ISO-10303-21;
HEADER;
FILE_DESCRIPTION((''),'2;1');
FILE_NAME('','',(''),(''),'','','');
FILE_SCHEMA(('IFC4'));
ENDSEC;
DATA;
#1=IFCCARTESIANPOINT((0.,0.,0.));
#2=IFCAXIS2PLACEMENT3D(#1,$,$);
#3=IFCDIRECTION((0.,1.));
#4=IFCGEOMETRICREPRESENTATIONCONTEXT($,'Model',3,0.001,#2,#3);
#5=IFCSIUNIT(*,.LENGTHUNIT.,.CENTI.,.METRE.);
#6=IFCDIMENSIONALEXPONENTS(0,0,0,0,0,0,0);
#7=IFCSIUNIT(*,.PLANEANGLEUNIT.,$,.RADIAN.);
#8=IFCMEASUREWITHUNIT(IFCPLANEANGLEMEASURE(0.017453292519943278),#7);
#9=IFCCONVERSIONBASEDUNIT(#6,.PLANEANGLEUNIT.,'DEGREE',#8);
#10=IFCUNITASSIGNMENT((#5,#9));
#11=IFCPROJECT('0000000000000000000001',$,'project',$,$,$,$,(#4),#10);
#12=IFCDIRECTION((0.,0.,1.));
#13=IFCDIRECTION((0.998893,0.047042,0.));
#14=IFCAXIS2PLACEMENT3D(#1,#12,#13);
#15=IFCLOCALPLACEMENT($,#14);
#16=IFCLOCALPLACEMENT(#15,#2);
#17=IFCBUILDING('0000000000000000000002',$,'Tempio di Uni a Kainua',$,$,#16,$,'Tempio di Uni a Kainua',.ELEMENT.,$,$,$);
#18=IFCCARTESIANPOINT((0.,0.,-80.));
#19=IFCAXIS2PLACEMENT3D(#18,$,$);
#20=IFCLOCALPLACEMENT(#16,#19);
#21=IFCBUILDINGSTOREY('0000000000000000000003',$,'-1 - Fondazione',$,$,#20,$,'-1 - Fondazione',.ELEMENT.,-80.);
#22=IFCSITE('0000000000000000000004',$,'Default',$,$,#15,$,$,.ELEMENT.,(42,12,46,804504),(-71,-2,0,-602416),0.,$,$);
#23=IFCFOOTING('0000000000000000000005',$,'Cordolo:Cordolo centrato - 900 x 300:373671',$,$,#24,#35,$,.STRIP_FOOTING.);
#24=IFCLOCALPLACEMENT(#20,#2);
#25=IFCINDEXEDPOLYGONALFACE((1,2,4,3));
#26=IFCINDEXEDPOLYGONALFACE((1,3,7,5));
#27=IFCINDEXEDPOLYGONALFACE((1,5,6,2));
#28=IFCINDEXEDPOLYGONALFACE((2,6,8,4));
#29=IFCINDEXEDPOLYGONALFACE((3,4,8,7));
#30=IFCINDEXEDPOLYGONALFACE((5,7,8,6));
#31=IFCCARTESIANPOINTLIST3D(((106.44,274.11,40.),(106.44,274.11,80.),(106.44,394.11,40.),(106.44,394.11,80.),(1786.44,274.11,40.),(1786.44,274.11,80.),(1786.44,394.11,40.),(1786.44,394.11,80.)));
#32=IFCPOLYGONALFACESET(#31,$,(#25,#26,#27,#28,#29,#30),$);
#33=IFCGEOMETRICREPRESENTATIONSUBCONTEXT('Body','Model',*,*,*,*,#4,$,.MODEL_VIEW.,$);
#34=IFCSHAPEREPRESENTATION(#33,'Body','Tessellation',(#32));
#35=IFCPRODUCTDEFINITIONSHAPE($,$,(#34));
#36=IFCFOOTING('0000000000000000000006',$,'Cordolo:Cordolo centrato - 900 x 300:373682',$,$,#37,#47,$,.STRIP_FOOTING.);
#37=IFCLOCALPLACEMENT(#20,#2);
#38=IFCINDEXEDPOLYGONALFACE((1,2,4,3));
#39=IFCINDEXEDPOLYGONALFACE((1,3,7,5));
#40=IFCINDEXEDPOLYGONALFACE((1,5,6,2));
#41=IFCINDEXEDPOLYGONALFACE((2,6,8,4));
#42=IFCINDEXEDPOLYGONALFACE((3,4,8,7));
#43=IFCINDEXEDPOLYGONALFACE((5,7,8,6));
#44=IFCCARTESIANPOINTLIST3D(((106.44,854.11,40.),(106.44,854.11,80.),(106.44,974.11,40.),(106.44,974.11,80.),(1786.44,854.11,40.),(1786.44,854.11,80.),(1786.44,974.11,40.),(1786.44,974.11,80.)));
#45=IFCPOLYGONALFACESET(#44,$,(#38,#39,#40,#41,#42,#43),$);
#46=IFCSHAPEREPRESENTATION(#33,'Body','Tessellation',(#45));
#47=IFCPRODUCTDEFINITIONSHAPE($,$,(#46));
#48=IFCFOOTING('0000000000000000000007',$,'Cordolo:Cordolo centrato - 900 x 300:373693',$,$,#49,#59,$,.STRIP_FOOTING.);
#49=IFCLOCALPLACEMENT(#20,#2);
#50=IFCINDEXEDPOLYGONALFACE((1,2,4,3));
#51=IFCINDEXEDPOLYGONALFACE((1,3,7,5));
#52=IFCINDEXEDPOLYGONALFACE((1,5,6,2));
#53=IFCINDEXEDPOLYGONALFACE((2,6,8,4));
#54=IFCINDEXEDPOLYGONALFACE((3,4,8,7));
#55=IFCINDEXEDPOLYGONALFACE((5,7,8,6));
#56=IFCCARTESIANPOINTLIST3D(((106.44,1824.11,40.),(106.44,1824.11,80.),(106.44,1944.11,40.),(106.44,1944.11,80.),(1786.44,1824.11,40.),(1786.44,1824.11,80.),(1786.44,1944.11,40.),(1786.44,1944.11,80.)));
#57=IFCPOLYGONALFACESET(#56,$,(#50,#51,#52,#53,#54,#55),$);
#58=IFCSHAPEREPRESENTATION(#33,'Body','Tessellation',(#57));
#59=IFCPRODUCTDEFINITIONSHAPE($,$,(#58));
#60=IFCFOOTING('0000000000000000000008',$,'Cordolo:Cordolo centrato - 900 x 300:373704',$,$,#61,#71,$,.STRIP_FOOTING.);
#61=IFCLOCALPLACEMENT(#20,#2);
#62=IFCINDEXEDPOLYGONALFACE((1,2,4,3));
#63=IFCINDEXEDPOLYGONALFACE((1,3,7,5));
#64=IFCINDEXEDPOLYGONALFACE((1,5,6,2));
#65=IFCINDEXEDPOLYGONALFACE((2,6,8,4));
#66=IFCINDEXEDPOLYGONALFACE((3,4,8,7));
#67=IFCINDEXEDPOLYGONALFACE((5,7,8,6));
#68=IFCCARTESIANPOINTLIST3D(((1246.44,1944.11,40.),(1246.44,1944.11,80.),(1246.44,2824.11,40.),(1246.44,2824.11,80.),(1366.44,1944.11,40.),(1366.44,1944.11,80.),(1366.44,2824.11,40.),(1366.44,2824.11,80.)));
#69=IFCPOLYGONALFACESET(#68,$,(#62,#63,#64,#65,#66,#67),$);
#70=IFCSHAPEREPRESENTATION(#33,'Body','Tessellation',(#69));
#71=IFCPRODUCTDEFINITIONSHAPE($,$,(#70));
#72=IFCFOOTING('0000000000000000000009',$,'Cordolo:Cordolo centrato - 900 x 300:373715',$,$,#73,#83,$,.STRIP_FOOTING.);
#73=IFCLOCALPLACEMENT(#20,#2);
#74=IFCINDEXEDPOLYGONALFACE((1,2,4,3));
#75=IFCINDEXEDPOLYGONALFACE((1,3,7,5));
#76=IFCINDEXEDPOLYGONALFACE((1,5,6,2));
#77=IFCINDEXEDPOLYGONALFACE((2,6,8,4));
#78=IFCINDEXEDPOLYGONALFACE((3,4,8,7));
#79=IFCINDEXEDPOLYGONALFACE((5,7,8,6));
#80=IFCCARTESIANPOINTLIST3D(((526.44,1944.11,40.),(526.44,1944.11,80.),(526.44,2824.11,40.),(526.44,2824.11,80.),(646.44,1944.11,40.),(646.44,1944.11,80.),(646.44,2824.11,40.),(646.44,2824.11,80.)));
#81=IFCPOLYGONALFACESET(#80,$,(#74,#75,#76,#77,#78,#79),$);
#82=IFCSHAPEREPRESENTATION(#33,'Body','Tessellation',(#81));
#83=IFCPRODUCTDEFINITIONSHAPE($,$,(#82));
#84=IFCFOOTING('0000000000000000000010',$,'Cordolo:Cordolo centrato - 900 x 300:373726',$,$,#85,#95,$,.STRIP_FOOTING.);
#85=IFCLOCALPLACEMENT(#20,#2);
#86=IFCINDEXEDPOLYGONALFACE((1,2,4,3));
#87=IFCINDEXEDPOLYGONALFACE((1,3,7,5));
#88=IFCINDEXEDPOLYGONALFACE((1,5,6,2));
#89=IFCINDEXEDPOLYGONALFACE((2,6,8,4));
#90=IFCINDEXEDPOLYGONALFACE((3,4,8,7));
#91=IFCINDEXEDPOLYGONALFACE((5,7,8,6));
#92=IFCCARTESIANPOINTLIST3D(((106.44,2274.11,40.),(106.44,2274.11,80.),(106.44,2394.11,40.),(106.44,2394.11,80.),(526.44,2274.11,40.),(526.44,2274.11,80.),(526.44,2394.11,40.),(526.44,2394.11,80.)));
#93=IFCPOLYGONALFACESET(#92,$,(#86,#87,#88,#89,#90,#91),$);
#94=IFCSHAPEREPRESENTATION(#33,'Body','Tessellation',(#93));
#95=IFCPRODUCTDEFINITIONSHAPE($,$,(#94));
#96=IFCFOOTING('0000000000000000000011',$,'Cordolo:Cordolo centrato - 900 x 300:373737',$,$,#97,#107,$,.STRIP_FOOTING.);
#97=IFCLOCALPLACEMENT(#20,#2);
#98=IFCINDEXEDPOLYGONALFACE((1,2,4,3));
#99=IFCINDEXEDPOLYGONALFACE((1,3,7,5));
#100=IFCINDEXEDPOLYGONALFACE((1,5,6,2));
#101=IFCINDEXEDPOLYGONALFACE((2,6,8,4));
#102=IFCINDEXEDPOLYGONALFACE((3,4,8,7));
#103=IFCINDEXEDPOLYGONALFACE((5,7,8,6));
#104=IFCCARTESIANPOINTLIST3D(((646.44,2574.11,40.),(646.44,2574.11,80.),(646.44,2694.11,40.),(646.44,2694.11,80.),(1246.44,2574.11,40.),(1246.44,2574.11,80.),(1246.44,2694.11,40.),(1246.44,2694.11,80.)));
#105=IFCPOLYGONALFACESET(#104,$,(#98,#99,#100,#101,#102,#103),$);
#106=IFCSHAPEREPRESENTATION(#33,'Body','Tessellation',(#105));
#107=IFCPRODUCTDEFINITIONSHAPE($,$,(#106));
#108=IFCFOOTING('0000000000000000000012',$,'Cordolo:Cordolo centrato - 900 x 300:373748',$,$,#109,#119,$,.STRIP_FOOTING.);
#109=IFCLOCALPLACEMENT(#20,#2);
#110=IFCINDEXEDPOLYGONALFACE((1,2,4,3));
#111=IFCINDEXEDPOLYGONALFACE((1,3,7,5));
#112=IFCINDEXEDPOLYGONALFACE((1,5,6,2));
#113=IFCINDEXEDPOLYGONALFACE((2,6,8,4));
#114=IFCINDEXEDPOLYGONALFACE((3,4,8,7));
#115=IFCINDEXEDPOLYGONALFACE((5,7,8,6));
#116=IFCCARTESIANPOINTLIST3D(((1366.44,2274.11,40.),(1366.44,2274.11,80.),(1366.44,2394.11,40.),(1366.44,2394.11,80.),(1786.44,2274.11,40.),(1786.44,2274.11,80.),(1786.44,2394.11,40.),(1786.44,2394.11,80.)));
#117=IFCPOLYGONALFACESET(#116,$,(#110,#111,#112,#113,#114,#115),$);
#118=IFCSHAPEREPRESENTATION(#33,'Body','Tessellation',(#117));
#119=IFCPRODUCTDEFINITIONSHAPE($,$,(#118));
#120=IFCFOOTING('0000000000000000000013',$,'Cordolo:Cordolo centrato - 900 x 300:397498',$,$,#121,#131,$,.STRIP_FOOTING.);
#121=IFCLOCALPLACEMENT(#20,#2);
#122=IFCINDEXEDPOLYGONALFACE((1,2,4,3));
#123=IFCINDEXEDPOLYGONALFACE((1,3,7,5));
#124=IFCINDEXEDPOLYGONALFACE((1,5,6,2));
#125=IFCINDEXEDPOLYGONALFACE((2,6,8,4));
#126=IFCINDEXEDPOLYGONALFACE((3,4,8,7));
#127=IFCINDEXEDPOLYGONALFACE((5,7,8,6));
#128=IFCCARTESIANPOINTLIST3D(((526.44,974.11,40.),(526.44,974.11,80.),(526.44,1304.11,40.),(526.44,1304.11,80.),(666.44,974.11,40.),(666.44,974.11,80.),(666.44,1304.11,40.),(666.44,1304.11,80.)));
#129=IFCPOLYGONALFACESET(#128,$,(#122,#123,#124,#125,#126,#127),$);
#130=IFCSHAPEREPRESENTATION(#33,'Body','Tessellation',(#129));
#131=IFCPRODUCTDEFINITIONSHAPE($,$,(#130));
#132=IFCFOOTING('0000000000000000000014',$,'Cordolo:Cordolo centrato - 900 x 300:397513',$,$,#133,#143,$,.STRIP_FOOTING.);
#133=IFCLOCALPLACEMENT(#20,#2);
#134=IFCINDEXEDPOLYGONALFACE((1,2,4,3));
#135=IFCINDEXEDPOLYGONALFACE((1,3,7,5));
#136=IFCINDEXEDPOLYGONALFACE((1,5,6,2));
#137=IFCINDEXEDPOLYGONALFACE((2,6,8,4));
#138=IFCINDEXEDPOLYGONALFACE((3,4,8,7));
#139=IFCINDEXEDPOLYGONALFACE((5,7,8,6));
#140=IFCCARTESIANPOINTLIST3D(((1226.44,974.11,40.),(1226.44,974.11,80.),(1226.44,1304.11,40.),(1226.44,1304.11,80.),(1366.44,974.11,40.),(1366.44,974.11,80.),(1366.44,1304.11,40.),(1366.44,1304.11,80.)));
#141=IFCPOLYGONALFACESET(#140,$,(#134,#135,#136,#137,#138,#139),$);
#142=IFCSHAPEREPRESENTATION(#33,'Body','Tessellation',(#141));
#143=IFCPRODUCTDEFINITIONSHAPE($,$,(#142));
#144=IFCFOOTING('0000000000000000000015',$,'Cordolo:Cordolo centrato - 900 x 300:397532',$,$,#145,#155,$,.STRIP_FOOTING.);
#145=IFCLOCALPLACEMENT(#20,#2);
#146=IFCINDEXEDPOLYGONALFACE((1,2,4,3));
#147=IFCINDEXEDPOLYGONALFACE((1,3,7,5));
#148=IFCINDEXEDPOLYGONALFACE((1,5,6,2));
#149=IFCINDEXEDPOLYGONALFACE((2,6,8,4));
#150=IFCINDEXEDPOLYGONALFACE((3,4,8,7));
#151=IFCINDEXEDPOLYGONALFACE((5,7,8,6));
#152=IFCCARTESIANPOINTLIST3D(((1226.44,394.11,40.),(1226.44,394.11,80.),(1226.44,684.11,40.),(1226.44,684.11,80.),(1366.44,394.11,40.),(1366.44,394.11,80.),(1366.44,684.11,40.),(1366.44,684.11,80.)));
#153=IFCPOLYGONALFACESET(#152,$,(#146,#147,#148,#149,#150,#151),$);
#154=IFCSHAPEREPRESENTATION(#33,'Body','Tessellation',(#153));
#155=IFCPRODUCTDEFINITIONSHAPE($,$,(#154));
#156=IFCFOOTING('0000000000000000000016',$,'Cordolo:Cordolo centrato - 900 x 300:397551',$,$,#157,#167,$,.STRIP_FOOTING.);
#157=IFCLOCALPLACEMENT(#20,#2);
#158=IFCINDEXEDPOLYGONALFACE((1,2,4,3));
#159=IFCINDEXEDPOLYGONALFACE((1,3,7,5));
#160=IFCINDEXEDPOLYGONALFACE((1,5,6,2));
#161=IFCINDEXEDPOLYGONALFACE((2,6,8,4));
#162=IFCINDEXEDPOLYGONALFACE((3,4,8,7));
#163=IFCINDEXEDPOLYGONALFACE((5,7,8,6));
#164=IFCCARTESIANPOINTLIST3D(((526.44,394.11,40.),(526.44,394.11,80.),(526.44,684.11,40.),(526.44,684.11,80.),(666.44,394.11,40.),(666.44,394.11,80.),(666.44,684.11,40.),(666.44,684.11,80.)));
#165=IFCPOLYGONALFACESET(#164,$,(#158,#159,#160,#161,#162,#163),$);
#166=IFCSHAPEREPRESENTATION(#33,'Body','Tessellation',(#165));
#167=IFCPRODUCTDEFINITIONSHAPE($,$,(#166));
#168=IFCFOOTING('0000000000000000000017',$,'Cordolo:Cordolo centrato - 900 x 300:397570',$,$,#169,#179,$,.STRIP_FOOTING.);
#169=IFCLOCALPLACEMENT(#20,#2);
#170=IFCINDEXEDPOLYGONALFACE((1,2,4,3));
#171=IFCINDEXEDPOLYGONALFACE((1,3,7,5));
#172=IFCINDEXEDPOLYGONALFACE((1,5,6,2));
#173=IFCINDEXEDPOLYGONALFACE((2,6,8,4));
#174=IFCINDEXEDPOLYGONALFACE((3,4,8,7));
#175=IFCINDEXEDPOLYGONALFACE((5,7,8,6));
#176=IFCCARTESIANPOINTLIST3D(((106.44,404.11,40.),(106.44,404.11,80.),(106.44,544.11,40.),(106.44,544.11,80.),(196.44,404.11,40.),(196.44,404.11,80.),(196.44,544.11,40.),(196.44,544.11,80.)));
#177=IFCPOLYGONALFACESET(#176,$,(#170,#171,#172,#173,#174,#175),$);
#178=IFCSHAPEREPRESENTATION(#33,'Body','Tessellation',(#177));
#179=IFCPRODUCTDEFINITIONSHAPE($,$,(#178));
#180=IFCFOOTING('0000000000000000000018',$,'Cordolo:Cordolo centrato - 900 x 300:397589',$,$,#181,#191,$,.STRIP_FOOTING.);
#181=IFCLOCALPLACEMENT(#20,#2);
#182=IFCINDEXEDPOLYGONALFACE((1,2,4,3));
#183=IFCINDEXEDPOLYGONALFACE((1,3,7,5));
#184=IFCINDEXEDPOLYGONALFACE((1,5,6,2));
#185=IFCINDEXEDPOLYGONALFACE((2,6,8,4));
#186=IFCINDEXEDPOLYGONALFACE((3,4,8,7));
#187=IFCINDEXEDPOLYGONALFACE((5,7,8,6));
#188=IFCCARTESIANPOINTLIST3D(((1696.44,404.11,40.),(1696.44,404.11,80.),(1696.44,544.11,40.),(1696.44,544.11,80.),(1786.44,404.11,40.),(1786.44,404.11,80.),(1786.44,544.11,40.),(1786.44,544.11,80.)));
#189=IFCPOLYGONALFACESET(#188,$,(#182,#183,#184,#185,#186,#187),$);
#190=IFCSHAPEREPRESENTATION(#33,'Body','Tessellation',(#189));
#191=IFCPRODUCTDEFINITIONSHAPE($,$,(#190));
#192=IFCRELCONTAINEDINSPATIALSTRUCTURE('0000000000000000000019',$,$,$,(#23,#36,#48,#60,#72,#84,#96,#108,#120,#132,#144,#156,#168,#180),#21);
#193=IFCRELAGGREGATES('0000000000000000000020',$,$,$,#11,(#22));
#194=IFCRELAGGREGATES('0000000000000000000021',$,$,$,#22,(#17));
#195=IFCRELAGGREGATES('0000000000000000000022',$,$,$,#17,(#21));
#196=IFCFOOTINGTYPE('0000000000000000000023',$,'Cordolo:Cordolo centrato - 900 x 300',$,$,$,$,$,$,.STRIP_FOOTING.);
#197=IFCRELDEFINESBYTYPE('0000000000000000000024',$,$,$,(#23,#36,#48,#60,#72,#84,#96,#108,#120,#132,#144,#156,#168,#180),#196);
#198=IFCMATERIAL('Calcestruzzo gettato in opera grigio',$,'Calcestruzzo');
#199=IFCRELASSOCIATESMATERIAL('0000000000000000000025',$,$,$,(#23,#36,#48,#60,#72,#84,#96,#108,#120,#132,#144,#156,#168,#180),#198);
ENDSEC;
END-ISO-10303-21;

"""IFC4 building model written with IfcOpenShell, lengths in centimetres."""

from ifc_helpers import new_model, entity, si_unit, converted_unit, direction, frame, frame_2d, origin, origin_2d_with_axis, place, context, subcontext, project, spatial, rectangle, extrude, material, type_object, element, save


model = new_model("IFC4")

# Units and contexts
model_context = context("Model", 3, precision=0.001, world=origin(), true_north=direction((0.0, 1.0)))
body_context = subcontext(model_context, "Body", "Model", "MODEL_VIEW")
ifc_project = project(units=[si_unit("LENGTHUNIT", "METRE", prefix="CENTI"), converted_unit("PLANEANGLEUNIT", "DEGREE", entity("IfcPlaneAngleMeasure", 0.017453292519943278), si_unit("PLANEANGLEUNIT", "RADIAN"), dimensions=[0, 0, 0, 0, 0, 0, 0])], contexts=[model_context])

# Site, building, storey
site_placement = place(None, frame((0.0, 0.0, 0.0), z_axis=(0.0, 0.0, 1.0), x_axis=(0.998893, 0.047042, 0.0)))
site = spatial("IfcSite", under=ifc_project, at=site_placement, Name="Default", CompositionType="ELEMENT", RefLatitude=(42, 12, 46, 804504), RefLongitude=(-71, -2, 0, -602416), RefElevation=0.0)
building_placement = place(site_placement, origin())
building = spatial("IfcBuilding", under=site, at=building_placement, Name="Tempio di Uni a Kainua", LongName="Tempio di Uni a Kainua", CompositionType="ELEMENT")
storey_placement = place(building_placement, frame((0.0, 0.0, -80.0)))
storey = spatial("IfcBuildingStorey", under=building, at=storey_placement, Name="-1 - Fondazione", LongName="-1 - Fondazione", CompositionType="ELEMENT", Elevation=-80.0)

# Footings
ifc_material = material(Name="Calcestruzzo gettato in opera grigio", Category="Calcestruzzo")
footing_type = type_object("IfcFootingType", Name="Cordolo:Cordolo centrato - 900 x 300", PredefinedType="STRIP_FOOTING")
footing_1_placement = place(storey_placement, frame((106.44, 274.11, 40.0)))
element("IfcFooting", 1, at=footing_1_placement, inside=storey, type_object=footing_type, material=ifc_material, Name="Cordolo:Cordolo centrato - 900 x 300:373671", PredefinedType="STRIP_FOOTING", context=body_context, shape_type="SweptSolid", body=[
    extrude(rectangle(XDim=1680.0, YDim=120.0, at=frame_2d((0.0, 30.0), x_axis=(1.0, 0.0))), frame((840.0, 90.0, 0.0), z_axis=(0.0, 0.0, 1.0), x_axis=(-1.0, 0.0, 0.0)), (0.0, 0.0, 1.0), 40.0),
])
footing_2_placement = place(storey_placement, frame((106.44, 854.11, 40.0)))
element("IfcFooting", 2, at=footing_2_placement, inside=storey, type_object=footing_type, material=ifc_material, Name="Cordolo:Cordolo centrato - 900 x 300:373682", PredefinedType="STRIP_FOOTING", context=body_context, shape_type="SweptSolid", body=[
    extrude(rectangle(XDim=1680.0, YDim=120.0, at=frame_2d((0.0, 30.0), x_axis=(1.0, 0.0))), frame((840.0, 90.0, 0.0), z_axis=(0.0, 0.0, 1.0), x_axis=(-1.0, 0.0, 0.0)), (0.0, 0.0, 1.0), 40.0),
])
footing_3_placement = place(storey_placement, frame((106.44, 1824.11, 40.0)))
element("IfcFooting", 3, at=footing_3_placement, inside=storey, type_object=footing_type, material=ifc_material, Name="Cordolo:Cordolo centrato - 900 x 300:373693", PredefinedType="STRIP_FOOTING", context=body_context, shape_type="SweptSolid", body=[
    extrude(rectangle(XDim=1680.0, YDim=120.0, at=frame_2d((0.0, 30.0), x_axis=(1.0, 0.0))), frame((840.0, 90.0, 0.0), z_axis=(0.0, 0.0, 1.0), x_axis=(-1.0, 0.0, 0.0)), (0.0, 0.0, 1.0), 40.0),
])
footing_4_placement = place(storey_placement, frame((1246.44, 1944.11, 40.0)))
element("IfcFooting", 4, at=footing_4_placement, inside=storey, type_object=footing_type, material=ifc_material, Name="Cordolo:Cordolo centrato - 900 x 300:373704", PredefinedType="STRIP_FOOTING", context=body_context, shape_type="SweptSolid", body=[
    extrude(rectangle(XDim=880.0, YDim=120.0, at=frame_2d((50.0, 0.0), x_axis=(1.0, 0.0))), frame((60.0, 490.0, 0.0), z_axis=(0.0, 0.0, 1.0), x_axis=(0.0, -1.0, 0.0)), (0.0, 0.0, 1.0), 40.0),
])
footing_5_placement = place(storey_placement, frame((526.44, 1944.11, 40.0)))
element("IfcFooting", 5, at=footing_5_placement, inside=storey, type_object=footing_type, material=ifc_material, Name="Cordolo:Cordolo centrato - 900 x 300:373715", PredefinedType="STRIP_FOOTING", context=body_context, shape_type="SweptSolid", body=[
    extrude(rectangle(XDim=880.0, YDim=120.0, at=frame_2d((50.0, 0.0), x_axis=(1.0, 0.0))), frame((60.0, 490.0, 0.0), z_axis=(0.0, 0.0, 1.0), x_axis=(0.0, -1.0, 0.0)), (0.0, 0.0, 1.0), 40.0),
])
footing_6_placement = place(storey_placement, frame((106.44, 2274.11, 40.0)))
element("IfcFooting", 6, at=footing_6_placement, inside=storey, type_object=footing_type, material=ifc_material, Name="Cordolo:Cordolo centrato - 900 x 300:373726", PredefinedType="STRIP_FOOTING", context=body_context, shape_type="SweptSolid", body=[
    extrude(rectangle(XDim=420.0, YDim=120.0, at=frame_2d((0.0, 0.0), x_axis=(1.0, 0.0))), frame((210.0, 60.0, 0.0)), (0.0, 0.0, 1.0), 40.0),
])
footing_7_placement = place(storey_placement, frame((646.44, 2574.11, 40.0)))
element("IfcFooting", 7, at=footing_7_placement, inside=storey, type_object=footing_type, material=ifc_material, Name="Cordolo:Cordolo centrato - 900 x 300:373737", PredefinedType="STRIP_FOOTING", context=body_context, shape_type="SweptSolid", body=[
    extrude(rectangle(XDim=600.0, YDim=120.0, at=frame_2d((0.0, 0.0), x_axis=(1.0, 0.0))), frame((300.0, 60.0, 0.0)), (0.0, 0.0, 1.0), 40.0),
])
footing_8_placement = place(storey_placement, frame((1366.44, 2274.11, 40.0)))
element("IfcFooting", 8, at=footing_8_placement, inside=storey, type_object=footing_type, material=ifc_material, Name="Cordolo:Cordolo centrato - 900 x 300:373748", PredefinedType="STRIP_FOOTING", context=body_context, shape_type="SweptSolid", body=[
    extrude(rectangle(XDim=420.0, YDim=120.0, at=origin_2d_with_axis()), frame((210.0, 60.0, 0.0)), (0.0, 0.0, 1.0), 40.0),
])
footing_9_placement = place(storey_placement, frame((526.44, 974.11, 40.0)))
element("IfcFooting", 9, at=footing_9_placement, inside=storey, type_object=footing_type, material=ifc_material, Name="Cordolo:Cordolo centrato - 900 x 300:397498", PredefinedType="STRIP_FOOTING", context=body_context, shape_type="SweptSolid", body=[
    extrude(rectangle(XDim=330.0, YDim=140.0, at=frame_2d((0.0, 0.0), x_axis=(1.0, 0.0))), frame((70.0, 165.0, 0.0), z_axis=(0.0, 0.0, 1.0), x_axis=(0.0, -1.0, 0.0)), (0.0, 0.0, 1.0), 40.0),
])
footing_10_placement = place(storey_placement, frame((1226.44, 974.11, 40.0)))
element("IfcFooting", 10, at=footing_10_placement, inside=storey, type_object=footing_type, material=ifc_material, Name="Cordolo:Cordolo centrato - 900 x 300:397513", PredefinedType="STRIP_FOOTING", context=body_context, shape_type="SweptSolid", body=[
    extrude(rectangle(XDim=330.0, YDim=140.0, at=frame_2d((0.0, 0.0), x_axis=(1.0, 0.0))), frame((70.0, 165.0, 0.0), z_axis=(0.0, 0.0, 1.0), x_axis=(0.0, -1.0, 0.0)), (0.0, 0.0, 1.0), 40.0),
])
footing_11_placement = place(storey_placement, frame((1226.44, 394.11, 40.0)))
element("IfcFooting", 11, at=footing_11_placement, inside=storey, type_object=footing_type, material=ifc_material, Name="Cordolo:Cordolo centrato - 900 x 300:397532", PredefinedType="STRIP_FOOTING", context=body_context, shape_type="SweptSolid", body=[
    extrude(rectangle(XDim=290.0, YDim=140.0, at=frame_2d((0.0, 0.0), x_axis=(1.0, 0.0))), frame((70.0, 145.0, 0.0), z_axis=(0.0, 0.0, 1.0), x_axis=(0.0, -1.0, 0.0)), (0.0, 0.0, 1.0), 40.0),
])
footing_12_placement = place(storey_placement, frame((526.44, 394.11, 40.0)))
element("IfcFooting", 12, at=footing_12_placement, inside=storey, type_object=footing_type, material=ifc_material, Name="Cordolo:Cordolo centrato - 900 x 300:397551", PredefinedType="STRIP_FOOTING", context=body_context, shape_type="SweptSolid", body=[
    extrude(rectangle(XDim=290.0, YDim=140.0, at=origin_2d_with_axis()), frame((70.0, 145.0, 0.0), z_axis=(0.0, 0.0, 1.0), x_axis=(0.0, -1.0, 0.0)), (0.0, 0.0, 1.0), 40.0),
])
footing_13_placement = place(storey_placement, frame((106.44, 404.11, 40.0)))
element("IfcFooting", 13, at=footing_13_placement, inside=storey, type_object=footing_type, material=ifc_material, Name="Cordolo:Cordolo centrato - 900 x 300:397570", PredefinedType="STRIP_FOOTING", context=body_context, shape_type="SweptSolid", body=[
    extrude(rectangle(XDim=90.0, YDim=140.0, at=frame_2d((0.0, 0.0), x_axis=(1.0, 0.0))), frame((45.0, 70.0, 0.0), z_axis=(0.0, 0.0, 1.0), x_axis=(-1.0, 0.0, 0.0)), (0.0, 0.0, 1.0), 40.0),
])
footing_14_placement = place(storey_placement, frame((1696.44, 404.11, 40.0)))
element("IfcFooting", 14, at=footing_14_placement, inside=storey, type_object=footing_type, material=ifc_material, Name="Cordolo:Cordolo centrato - 900 x 300:397589", PredefinedType="STRIP_FOOTING", context=body_context, shape_type="SweptSolid", body=[
    extrude(rectangle(XDim=90.0, YDim=140.0, at=frame_2d((0.0, 0.0), x_axis=(1.0, 0.0))), frame((45.0, 70.0, 0.0), z_axis=(0.0, 0.0, 1.0), x_axis=(-1.0, 0.0, 0.0)), (0.0, 0.0, 1.0), 40.0),
])

save(model, "model.ifc")
